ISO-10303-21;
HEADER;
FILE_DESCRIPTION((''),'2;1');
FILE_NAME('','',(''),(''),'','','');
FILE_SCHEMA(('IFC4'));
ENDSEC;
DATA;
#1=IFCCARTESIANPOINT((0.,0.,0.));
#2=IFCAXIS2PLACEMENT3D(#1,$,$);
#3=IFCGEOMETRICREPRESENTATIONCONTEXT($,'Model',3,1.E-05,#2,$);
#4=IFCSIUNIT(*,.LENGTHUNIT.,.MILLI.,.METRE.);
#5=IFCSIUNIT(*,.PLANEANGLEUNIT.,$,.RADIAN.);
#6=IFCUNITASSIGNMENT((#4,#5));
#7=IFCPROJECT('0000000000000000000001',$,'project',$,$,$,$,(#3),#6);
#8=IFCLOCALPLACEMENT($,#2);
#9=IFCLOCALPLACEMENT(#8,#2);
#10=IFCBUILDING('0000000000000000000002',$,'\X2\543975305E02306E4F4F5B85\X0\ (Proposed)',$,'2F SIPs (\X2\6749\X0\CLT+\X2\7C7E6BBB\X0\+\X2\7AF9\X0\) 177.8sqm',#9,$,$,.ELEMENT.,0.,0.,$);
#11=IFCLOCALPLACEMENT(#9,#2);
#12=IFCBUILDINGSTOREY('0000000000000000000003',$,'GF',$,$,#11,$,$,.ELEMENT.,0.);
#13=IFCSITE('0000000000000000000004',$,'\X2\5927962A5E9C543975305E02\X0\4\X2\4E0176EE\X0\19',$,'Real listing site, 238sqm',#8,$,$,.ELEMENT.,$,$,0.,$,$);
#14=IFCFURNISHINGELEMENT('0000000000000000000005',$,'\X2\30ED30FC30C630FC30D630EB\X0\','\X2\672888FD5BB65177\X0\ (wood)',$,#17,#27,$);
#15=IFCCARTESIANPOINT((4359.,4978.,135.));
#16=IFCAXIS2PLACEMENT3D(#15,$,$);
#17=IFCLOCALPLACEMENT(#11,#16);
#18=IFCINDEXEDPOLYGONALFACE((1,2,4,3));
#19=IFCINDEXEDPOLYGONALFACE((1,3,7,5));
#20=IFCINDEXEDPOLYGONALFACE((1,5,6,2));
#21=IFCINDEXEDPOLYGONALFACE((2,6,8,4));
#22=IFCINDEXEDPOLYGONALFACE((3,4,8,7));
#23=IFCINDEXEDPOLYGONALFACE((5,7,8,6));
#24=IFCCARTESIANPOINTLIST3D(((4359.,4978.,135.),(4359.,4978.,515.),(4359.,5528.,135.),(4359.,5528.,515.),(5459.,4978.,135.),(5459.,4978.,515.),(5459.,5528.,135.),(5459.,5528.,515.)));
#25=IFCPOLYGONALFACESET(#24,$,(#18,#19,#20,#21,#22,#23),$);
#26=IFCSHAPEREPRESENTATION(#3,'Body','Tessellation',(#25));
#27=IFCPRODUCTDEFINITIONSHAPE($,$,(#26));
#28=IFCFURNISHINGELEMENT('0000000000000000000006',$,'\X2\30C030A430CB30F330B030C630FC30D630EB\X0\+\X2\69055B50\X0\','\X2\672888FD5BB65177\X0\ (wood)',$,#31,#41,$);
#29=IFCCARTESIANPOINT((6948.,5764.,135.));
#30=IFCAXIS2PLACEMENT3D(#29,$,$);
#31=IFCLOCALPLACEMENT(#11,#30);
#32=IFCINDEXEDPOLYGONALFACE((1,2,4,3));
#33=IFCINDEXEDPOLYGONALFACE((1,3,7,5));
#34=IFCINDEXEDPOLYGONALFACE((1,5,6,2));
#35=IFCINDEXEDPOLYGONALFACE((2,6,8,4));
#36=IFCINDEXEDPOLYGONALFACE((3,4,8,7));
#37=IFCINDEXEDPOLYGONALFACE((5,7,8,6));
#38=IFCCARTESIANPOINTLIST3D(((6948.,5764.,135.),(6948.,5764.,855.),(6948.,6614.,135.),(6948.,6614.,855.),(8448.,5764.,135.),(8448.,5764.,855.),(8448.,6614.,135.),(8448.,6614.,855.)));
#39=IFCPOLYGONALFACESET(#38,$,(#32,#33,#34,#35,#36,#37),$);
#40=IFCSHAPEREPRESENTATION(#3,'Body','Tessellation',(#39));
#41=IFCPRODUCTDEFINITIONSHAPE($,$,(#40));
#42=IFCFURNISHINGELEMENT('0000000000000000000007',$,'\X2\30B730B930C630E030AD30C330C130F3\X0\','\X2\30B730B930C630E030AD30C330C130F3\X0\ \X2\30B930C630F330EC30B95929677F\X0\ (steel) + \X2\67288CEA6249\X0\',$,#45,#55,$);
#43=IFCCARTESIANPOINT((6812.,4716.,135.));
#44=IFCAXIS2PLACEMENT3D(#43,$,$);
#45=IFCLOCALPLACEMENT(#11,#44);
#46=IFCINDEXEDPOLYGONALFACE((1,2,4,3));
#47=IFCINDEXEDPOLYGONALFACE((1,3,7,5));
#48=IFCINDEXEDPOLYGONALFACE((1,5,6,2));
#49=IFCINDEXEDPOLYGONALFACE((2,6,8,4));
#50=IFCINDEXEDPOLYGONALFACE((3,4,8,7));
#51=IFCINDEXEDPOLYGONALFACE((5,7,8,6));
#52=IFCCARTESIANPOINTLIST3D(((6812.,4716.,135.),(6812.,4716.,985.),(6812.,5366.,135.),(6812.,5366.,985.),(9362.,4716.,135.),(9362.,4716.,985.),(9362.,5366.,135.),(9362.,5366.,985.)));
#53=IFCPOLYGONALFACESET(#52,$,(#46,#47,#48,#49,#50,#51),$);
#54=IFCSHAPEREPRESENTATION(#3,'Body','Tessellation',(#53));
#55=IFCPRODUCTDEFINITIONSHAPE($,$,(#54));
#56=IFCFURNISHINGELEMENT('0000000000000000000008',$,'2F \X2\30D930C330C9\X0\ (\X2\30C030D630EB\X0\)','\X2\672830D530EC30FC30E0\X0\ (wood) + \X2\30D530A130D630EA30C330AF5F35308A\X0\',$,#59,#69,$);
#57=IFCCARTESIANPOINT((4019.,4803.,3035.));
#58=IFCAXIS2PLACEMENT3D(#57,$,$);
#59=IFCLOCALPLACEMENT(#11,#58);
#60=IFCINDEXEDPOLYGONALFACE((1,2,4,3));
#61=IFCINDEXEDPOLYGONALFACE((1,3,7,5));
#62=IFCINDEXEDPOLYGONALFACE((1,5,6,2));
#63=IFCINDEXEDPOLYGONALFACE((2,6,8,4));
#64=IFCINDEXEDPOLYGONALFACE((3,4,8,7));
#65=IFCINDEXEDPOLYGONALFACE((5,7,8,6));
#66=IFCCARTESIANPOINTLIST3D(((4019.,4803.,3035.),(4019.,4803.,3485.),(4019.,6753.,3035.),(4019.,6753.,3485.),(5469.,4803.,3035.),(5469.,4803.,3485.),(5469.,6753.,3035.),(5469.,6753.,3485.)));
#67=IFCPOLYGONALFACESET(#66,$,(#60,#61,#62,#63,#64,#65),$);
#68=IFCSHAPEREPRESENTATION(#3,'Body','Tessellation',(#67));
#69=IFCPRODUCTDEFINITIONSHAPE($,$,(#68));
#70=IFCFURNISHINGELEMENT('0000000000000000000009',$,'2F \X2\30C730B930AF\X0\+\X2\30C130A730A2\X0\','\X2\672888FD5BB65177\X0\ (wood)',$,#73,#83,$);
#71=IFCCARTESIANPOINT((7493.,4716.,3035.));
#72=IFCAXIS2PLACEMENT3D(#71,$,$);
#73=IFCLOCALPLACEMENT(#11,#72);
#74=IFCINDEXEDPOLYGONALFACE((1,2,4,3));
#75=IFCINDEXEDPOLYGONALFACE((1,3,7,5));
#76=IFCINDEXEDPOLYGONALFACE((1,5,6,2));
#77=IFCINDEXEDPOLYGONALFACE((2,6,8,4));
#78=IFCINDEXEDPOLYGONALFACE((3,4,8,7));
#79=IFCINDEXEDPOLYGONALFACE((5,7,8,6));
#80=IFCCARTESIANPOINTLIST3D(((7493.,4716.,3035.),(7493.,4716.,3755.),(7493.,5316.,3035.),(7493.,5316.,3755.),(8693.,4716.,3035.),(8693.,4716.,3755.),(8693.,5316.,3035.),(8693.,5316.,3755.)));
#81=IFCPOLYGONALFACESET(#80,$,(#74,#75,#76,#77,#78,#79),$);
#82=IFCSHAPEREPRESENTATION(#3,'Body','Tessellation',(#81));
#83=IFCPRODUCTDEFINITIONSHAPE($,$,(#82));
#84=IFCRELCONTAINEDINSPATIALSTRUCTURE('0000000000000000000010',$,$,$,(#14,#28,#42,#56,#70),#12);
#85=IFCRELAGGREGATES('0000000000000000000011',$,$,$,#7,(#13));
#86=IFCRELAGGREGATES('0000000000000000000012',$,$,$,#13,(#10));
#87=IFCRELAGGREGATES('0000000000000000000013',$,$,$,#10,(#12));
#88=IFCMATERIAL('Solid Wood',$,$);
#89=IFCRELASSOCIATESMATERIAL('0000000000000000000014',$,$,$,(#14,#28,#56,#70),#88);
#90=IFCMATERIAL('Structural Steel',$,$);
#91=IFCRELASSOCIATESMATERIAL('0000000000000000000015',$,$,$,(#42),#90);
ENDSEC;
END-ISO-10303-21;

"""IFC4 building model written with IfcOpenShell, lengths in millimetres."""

from ifc_helpers import new_model, si_unit, frame, frame_2d, origin, place, context, project, spatial, rectangle, extrude, material, element, save


model = new_model("IFC4")

# Units and contexts
model_context = context("Model", 3, precision=1e-05, world=origin())
ifc_project = project(units=[si_unit("LENGTHUNIT", "METRE", prefix="MILLI"), si_unit("PLANEANGLEUNIT", "RADIAN")], contexts=[model_context])

# Site, building, storey
site_placement = place(None, origin())
site = spatial("IfcSite", under=ifc_project, at=site_placement, Name="大阪府吹田市4丁目19", ObjectType="Real listing site, 238sqm", CompositionType="ELEMENT", RefElevation=0.0)
building_placement = place(site_placement, origin())
building = spatial("IfcBuilding", under=site, at=building_placement, Name="吹田市の住宅 (Proposed)", ObjectType="2F SIPs (杉CLT+籾殻+竹) 177.8sqm", CompositionType="ELEMENT", ElevationOfRefHeight=0.0, ElevationOfTerrain=0.0)
storey_placement = place(building_placement, origin())
storey = spatial("IfcBuildingStorey", under=building, at=storey_placement, Name="GF", CompositionType="ELEMENT", Elevation=0.0)

# Shared definitions
ifc_material_1 = material(Name="Solid Wood")

# Shared definitions
ifc_material_2 = material(Name="Structural Steel")

# Furnishing elements
furnishing_1_placement = place(storey_placement, frame((4359.0, 4978.0, 135.0)))
element("IfcFurnishingElement", 1, at=furnishing_1_placement, inside=storey, material=ifc_material_1, Name="ローテーブル", Description="木製家具 (wood)", context=model_context, shape_type="SweptSolid", body=[
    extrude(rectangle(XDim=1100.0, YDim=550.0, at=frame_2d((550.0, 275.0))), frame((4359.0, 4978.0, 135.0)), (0.0, 0.0, 1.0), 380.0),
])
furnishing_2_placement = place(storey_placement, frame((6948.0, 5764.0, 135.0)))
element("IfcFurnishingElement", 2, at=furnishing_2_placement, inside=storey, material=ifc_material_1, Name="ダイニングテーブル+椅子", Description="木製家具 (wood)", context=model_context, shape_type="SweptSolid", body=[
    extrude(rectangle(XDim=1500.0, YDim=850.0, at=frame_2d((750.0, 425.0))), frame((6948.0, 5764.0, 135.0)), (0.0, 0.0, 1.0), 720.0),
])
furnishing_3_placement = place(storey_placement, frame((6812.0, 4716.0, 135.0)))
element("IfcFurnishingElement", 3, at=furnishing_3_placement, inside=storey, material=ifc_material_2, Name="システムキッチン", Description="システムキッチン ステンレス天板 (steel) + 木質扉", context=model_context, shape_type="SweptSolid", body=[
    extrude(rectangle(XDim=2550.0, YDim=650.0, at=frame_2d((1275.0, 325.0))), frame((6812.0, 4716.0, 135.0)), (0.0, 0.0, 1.0), 850.0),
])
furnishing_4_placement = place(storey_placement, frame((4019.0, 4803.0, 3035.0)))
element("IfcFurnishingElement", 4, at=furnishing_4_placement, inside=storey, material=ifc_material_1, Name="2F ベッド (ダブル)", Description="木フレーム (wood) + ファブリック張り", context=model_context, shape_type="SweptSolid", body=[
    extrude(rectangle(XDim=1450.0, YDim=1950.0, at=frame_2d((725.0, 975.0))), frame((4019.0, 4803.0, 3035.0)), (0.0, 0.0, 1.0), 450.0),
])
furnishing_5_placement = place(storey_placement, frame((7493.0, 4716.0, 3035.0)))
element("IfcFurnishingElement", 5, at=furnishing_5_placement, inside=storey, material=ifc_material_1, Name="2F デスク+チェア", Description="木製家具 (wood)", context=model_context, shape_type="SweptSolid", body=[
    extrude(rectangle(XDim=1200.0, YDim=600.0, at=frame_2d((600.0, 300.0))), frame((7493.0, 4716.0, 3035.0)), (0.0, 0.0, 1.0), 720.0),
])

save(model, "model.ifc")
